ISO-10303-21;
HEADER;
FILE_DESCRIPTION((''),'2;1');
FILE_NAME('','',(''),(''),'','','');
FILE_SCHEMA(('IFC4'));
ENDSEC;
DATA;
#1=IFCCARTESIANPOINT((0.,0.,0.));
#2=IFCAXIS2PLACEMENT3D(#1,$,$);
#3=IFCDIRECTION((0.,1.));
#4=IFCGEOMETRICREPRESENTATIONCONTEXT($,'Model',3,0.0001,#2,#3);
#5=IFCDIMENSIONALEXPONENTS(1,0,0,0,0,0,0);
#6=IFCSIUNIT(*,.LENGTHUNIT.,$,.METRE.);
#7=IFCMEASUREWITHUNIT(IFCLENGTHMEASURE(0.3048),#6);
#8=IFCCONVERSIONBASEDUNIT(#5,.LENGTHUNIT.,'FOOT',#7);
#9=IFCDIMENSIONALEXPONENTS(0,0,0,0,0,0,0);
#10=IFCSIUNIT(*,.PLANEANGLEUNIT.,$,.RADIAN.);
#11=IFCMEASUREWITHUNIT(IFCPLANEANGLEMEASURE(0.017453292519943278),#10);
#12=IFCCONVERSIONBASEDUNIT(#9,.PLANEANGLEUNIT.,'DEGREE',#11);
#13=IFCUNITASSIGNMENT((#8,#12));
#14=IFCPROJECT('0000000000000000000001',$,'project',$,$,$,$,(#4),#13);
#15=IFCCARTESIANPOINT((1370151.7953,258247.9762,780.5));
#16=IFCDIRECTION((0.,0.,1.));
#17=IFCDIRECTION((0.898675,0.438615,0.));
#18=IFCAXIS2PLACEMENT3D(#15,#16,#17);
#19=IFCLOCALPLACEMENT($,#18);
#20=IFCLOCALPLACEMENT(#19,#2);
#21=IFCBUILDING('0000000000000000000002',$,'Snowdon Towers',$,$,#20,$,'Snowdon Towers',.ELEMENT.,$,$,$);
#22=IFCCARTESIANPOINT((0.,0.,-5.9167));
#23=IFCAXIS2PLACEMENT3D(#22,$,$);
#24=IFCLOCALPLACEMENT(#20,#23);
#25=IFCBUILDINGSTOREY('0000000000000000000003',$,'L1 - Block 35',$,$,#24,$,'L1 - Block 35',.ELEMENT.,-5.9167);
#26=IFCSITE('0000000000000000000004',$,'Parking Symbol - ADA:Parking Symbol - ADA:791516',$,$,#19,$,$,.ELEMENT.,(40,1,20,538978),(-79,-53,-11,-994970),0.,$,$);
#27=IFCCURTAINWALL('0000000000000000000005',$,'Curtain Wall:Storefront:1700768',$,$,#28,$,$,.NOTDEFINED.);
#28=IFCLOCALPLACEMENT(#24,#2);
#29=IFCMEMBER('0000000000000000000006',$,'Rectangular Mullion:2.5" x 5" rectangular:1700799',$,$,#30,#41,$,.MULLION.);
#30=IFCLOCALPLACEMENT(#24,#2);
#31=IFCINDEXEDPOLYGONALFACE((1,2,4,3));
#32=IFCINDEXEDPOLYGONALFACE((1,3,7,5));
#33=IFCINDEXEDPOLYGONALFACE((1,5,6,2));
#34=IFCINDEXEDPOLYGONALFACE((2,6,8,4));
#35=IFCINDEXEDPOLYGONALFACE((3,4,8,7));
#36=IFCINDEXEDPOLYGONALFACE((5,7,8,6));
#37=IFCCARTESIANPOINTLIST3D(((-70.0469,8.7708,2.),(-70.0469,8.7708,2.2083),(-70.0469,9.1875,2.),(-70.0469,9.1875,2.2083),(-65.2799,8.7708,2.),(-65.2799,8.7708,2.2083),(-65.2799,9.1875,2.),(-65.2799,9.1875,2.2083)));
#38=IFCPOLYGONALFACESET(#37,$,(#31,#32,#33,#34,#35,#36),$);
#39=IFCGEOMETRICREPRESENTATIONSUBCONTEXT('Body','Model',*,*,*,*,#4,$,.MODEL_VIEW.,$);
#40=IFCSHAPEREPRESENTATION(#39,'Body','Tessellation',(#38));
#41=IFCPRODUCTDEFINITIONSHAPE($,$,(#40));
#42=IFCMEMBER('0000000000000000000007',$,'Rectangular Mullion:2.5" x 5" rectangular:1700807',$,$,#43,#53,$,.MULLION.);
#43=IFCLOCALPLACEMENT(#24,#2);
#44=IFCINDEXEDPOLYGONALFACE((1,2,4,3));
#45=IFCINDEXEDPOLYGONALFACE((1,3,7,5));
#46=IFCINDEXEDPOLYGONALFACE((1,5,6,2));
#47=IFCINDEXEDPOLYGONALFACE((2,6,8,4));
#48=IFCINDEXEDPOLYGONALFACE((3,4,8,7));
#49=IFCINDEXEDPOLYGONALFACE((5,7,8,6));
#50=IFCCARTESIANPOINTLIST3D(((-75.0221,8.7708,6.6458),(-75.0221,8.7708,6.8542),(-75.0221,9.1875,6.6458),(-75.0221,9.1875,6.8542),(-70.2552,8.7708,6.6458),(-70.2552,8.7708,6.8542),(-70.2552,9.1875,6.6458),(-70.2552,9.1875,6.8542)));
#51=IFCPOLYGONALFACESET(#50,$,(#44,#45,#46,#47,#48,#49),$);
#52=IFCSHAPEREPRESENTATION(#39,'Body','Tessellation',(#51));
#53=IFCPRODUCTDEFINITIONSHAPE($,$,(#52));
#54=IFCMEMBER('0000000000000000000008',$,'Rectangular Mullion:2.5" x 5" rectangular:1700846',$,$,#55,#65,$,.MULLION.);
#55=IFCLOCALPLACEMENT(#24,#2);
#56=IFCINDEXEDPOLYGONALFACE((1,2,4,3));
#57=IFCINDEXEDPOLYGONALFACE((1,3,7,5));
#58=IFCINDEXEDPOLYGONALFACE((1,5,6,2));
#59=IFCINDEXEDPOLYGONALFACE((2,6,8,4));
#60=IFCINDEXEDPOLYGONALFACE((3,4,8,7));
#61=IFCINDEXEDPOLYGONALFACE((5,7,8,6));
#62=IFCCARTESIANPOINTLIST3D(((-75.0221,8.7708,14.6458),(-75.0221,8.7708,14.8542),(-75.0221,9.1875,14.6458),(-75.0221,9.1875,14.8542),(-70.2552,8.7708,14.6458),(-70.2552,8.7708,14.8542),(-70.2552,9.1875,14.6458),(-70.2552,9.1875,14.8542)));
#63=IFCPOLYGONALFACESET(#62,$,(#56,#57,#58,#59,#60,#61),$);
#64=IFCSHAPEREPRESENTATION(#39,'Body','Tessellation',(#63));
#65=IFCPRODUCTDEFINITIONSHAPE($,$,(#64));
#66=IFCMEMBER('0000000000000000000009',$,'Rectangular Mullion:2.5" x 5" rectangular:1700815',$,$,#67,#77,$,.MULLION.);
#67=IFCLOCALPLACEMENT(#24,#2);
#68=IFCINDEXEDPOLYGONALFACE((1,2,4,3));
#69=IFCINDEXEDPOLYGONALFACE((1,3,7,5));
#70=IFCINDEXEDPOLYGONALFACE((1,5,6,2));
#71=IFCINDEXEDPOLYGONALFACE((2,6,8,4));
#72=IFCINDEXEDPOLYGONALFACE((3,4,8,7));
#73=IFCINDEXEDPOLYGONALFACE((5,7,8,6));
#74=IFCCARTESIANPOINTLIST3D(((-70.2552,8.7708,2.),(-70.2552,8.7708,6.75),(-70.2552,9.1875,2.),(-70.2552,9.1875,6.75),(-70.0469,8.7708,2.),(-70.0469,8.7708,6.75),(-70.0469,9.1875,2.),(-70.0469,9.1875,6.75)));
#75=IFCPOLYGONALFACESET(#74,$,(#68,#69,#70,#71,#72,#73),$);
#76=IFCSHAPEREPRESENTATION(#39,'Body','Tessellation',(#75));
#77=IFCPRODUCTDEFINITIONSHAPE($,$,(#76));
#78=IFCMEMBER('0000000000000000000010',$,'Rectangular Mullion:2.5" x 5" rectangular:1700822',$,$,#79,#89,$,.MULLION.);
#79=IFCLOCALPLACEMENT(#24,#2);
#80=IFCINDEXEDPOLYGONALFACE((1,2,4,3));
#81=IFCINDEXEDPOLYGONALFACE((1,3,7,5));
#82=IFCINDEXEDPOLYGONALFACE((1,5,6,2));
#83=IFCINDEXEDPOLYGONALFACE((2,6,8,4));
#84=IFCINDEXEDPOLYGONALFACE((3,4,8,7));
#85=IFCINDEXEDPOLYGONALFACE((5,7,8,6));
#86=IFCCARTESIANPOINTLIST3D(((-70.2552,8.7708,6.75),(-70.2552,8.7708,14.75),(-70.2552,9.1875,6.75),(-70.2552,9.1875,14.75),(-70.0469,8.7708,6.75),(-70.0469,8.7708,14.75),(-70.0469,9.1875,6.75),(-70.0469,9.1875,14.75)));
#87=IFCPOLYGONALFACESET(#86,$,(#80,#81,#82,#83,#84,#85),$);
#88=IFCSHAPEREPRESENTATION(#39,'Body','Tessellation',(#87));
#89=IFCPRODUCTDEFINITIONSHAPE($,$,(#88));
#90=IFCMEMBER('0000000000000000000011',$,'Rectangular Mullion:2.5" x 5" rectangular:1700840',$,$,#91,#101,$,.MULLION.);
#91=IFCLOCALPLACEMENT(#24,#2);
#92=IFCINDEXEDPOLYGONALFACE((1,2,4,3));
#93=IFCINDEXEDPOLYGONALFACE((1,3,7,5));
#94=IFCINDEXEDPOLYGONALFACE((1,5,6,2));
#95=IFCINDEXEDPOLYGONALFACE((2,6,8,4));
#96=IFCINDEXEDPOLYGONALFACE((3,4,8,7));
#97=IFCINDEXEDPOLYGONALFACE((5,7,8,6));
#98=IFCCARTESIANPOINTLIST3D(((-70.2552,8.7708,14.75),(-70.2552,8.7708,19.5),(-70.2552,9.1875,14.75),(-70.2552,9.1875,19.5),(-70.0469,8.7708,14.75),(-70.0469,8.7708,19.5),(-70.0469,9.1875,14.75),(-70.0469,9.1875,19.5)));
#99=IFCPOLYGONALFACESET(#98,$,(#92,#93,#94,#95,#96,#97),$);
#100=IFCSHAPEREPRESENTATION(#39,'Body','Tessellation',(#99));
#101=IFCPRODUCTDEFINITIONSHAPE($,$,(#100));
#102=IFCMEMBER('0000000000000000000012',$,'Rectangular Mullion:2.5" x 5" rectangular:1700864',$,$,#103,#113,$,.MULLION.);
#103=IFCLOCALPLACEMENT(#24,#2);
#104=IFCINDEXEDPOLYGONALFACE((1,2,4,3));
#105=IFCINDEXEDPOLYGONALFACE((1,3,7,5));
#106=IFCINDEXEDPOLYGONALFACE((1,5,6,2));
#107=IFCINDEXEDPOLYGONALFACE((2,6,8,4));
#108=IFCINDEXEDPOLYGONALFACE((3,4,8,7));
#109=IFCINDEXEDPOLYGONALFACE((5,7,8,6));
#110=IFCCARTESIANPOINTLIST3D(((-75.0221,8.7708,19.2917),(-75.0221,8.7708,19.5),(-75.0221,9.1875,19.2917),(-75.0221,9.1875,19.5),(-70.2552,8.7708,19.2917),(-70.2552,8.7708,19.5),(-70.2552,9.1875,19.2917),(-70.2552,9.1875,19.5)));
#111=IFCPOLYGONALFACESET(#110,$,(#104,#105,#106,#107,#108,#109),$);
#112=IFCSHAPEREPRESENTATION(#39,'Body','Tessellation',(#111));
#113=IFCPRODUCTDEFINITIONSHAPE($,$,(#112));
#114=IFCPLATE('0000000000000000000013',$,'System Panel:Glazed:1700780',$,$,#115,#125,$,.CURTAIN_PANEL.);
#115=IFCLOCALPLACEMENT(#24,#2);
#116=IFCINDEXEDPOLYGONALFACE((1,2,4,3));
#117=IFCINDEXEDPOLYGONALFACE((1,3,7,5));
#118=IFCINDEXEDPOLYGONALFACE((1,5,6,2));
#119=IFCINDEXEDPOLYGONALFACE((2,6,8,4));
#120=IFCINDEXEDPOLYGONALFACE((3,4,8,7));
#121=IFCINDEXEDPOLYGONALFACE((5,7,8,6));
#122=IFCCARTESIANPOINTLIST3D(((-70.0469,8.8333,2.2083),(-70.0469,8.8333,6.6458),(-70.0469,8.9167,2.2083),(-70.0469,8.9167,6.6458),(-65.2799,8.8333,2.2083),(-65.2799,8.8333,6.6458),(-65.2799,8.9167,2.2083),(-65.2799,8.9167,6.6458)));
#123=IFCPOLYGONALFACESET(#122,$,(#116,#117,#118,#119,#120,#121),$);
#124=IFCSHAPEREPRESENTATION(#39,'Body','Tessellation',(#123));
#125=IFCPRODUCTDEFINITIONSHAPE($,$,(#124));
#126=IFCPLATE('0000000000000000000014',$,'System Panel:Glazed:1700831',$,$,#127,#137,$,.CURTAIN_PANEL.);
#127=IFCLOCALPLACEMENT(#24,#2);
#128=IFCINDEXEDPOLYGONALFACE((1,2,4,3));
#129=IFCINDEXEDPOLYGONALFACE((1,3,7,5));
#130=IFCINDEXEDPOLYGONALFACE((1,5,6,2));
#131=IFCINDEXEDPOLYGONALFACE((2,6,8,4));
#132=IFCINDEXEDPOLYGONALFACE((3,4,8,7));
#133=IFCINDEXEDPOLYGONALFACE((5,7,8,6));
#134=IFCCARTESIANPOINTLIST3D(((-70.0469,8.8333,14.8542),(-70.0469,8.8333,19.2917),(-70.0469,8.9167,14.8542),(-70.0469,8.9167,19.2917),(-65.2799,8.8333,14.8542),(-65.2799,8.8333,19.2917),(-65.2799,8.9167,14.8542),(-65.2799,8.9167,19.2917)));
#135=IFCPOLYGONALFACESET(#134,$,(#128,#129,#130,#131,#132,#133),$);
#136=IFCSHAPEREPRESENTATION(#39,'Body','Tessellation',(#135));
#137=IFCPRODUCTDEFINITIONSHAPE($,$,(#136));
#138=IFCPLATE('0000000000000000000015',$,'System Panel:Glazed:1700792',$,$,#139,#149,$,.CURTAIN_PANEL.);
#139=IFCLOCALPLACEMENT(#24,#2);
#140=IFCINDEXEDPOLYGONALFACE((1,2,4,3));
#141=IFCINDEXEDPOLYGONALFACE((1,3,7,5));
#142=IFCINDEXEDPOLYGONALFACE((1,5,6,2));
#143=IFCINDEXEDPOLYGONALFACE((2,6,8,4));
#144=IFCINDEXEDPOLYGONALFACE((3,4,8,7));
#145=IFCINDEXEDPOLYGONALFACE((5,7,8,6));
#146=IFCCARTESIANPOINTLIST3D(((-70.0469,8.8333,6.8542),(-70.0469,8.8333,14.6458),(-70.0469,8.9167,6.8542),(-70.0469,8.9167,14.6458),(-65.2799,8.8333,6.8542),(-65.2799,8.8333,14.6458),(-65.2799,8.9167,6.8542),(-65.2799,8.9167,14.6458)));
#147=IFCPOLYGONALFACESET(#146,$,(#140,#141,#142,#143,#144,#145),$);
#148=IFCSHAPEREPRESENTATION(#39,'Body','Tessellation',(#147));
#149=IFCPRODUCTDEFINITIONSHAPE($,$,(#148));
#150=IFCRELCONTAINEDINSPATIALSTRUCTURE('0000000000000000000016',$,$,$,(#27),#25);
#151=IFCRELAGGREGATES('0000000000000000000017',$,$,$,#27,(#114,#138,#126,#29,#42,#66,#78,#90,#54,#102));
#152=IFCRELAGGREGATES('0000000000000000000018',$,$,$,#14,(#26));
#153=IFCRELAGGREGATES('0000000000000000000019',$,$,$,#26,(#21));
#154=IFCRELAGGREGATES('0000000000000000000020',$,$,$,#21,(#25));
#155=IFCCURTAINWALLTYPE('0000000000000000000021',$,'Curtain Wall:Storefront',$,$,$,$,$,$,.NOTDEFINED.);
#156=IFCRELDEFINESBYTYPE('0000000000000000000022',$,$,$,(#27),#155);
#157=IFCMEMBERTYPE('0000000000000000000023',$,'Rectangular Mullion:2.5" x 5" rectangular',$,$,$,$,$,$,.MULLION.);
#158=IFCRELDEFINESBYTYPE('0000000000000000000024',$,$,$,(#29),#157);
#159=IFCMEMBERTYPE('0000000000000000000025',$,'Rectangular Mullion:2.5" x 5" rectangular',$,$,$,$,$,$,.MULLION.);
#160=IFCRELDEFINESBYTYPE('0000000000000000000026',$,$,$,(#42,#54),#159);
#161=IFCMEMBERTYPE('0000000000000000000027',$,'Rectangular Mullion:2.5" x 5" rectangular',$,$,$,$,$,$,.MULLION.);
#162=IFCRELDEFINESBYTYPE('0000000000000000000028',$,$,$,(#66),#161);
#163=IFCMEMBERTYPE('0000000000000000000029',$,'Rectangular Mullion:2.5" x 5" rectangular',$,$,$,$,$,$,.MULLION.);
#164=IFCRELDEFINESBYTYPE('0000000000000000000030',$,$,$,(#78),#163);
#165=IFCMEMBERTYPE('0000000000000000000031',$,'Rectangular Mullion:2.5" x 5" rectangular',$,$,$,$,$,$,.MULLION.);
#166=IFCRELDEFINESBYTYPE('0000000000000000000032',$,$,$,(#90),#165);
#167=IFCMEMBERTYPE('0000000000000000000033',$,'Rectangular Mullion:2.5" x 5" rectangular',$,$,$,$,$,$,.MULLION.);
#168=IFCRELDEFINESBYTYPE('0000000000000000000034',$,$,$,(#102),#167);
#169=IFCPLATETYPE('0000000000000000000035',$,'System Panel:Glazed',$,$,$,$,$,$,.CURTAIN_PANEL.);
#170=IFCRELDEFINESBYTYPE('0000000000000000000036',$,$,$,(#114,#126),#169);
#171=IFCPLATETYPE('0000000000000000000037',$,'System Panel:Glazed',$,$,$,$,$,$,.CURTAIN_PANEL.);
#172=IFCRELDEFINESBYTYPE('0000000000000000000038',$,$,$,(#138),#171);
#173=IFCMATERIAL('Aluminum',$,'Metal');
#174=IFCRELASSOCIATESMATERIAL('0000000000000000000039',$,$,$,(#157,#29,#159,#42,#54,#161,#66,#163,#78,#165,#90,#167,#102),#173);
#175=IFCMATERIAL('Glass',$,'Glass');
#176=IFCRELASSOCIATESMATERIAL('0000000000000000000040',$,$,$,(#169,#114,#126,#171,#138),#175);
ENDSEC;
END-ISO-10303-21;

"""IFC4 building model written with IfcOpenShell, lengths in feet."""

from ifc_helpers import new_model, entity, si_unit, converted_unit, direction, frame, origin, place, context, subcontext, project, spatial, indexed_curve, outline, extrude, source, transform, mapped, material, type_object, type_shapes, element, aggregate, save


model = new_model("IFC4")

# Units and contexts
model_context = context("Model", 3, precision=0.0001, world=origin(), true_north=direction((0.0, 1.0)))
body_context = subcontext(model_context, "Body", "Model", "MODEL_VIEW")
ifc_project = project(units=[converted_unit("LENGTHUNIT", "FOOT", entity("IfcLengthMeasure", 0.3048), si_unit("LENGTHUNIT", "METRE"), dimensions=[1, 0, 0, 0, 0, 0, 0]), converted_unit("PLANEANGLEUNIT", "DEGREE", entity("IfcPlaneAngleMeasure", 0.017453292519943278), si_unit("PLANEANGLEUNIT", "RADIAN"), dimensions=[0, 0, 0, 0, 0, 0, 0])], contexts=[model_context])

# Site, building, storey
site_placement = place(None, frame((1370151.7953, 258247.9762, 780.5), z_axis=(0.0, 0.0, 1.0), x_axis=(0.898675, 0.438615, 0.0)))
site = spatial("IfcSite", under=ifc_project, at=site_placement, Name="Parking Symbol - ADA:Parking Symbol - ADA:791516", CompositionType="ELEMENT", RefLatitude=(40, 1, 20, 538978), RefLongitude=(-79, -53, -11, -994970), RefElevation=0.0)
building_placement = place(site_placement, origin())
building = spatial("IfcBuilding", under=site, at=building_placement, Name="Snowdon Towers", LongName="Snowdon Towers", CompositionType="ELEMENT")
storey_placement = place(building_placement, frame((0.0, 0.0, -5.9167)))
storey = spatial("IfcBuildingStorey", under=building, at=storey_placement, Name="L1 - Block 35", LongName="L1 - Block 35", CompositionType="ELEMENT", Elevation=-5.9167)

# Curtain wall, members, plates
curtain_wall_type = type_object("IfcCurtainWallType", Name="Curtain Wall:Storefront", PredefinedType="NOTDEFINED")
curtain_wall_placement = place(storey_placement, frame((0.0, 0.0, 5.9167)))
curtain_wall = element("IfcCurtainWall", 1, at=curtain_wall_placement, inside=storey, type_object=curtain_wall_type, Name="Curtain Wall:Storefront:1700768", PredefinedType="NOTDEFINED")
ifc_material_1 = material(Name="Aluminum", Category="Metal")
member_type_1 = type_object("IfcMemberType", Name="Rectangular Mullion:2.5\" x 5\" rectangular", PredefinedType="MULLION", material=ifc_material_1)
shared_shape_1 = source(origin(), body_context, "Body", "SweptSolid", [
    extrude(outline(indexed_curve([(-0.1042, -0.2083), (0.1042, -0.2083), (0.1042, 0.2083), (-0.1042, 0.2083), (-0.1042, -0.2083)], self_intersect=False)), frame((-0.1042, 0.0, -4.7669), z_axis=(0.0, 0.0, 1.0), x_axis=(-1.0, 0.0, 0.0)), (0.0, 0.0, 1.0), 4.7669),
])
type_shapes(member_type_1, [shared_shape_1])
member_1_placement = place(curtain_wall_placement, frame((-70.0469, 8.9792, -3.9167), z_axis=(-1.0, 0.0, 0.0), x_axis=(0.0, 0.0, -1.0)))
member_1 = element("IfcMember", 2, at=member_1_placement, type_object=member_type_1, material=ifc_material_1, Name="Rectangular Mullion:2.5\" x 5\" rectangular:1700799", PredefinedType="MULLION", context=body_context, shape_type="MappedRepresentation", body=[
    mapped(shared_shape_1, transform((0.0, 0.0, 0.0), scale=1.0)),
])
member_type_2 = type_object("IfcMemberType", Name="Rectangular Mullion:2.5\" x 5\" rectangular", PredefinedType="MULLION", material=ifc_material_1)
shared_shape_2 = source(origin(), body_context, "Body", "SweptSolid", [
    extrude(outline(indexed_curve([(-0.1042, -0.2083), (0.1042, -0.2083), (0.1042, 0.2083), (-0.1042, 0.2083), (-0.1042, -0.2083)], self_intersect=False)), frame((0.0, 0.0, -4.7669), z_axis=(0.0, 0.0, 1.0), x_axis=(-1.0, 0.0, 0.0)), (0.0, 0.0, 1.0), 4.7669),
])
type_shapes(member_type_2, [shared_shape_2])
member_2_placement = place(curtain_wall_placement, frame((-70.2552, 8.9792, 0.8333), z_axis=(1.0, 0.0, 0.0), x_axis=(0.0, 0.0, 1.0)))
member_2 = element("IfcMember", 3, at=member_2_placement, type_object=member_type_2, material=ifc_material_1, Name="Rectangular Mullion:2.5\" x 5\" rectangular:1700807", PredefinedType="MULLION", context=body_context, shape_type="MappedRepresentation", body=[
    mapped(shared_shape_2, transform((0.0, 0.0, 0.0), scale=1.0)),
])
member_3_placement = place(curtain_wall_placement, frame((-70.2552, 8.9792, 8.8333), z_axis=(1.0, 0.0, 0.0), x_axis=(0.0, 0.0, 1.0)))
member_3 = element("IfcMember", 4, at=member_3_placement, type_object=member_type_2, material=ifc_material_1, Name="Rectangular Mullion:2.5\" x 5\" rectangular:1700846", PredefinedType="MULLION", context=body_context, shape_type="MappedRepresentation", body=[
    mapped(shared_shape_2, transform((0.0, 0.0, 0.0), scale=1.0)),
])
member_type_3 = type_object("IfcMemberType", Name="Rectangular Mullion:2.5\" x 5\" rectangular", PredefinedType="MULLION", material=ifc_material_1)
shared_shape_3 = source(origin(), body_context, "Body", "SweptSolid", [
    extrude(outline(indexed_curve([(-0.1042, -0.2083), (0.1042, -0.2083), (0.1042, 0.2083), (-0.1042, 0.2083), (-0.1042, -0.2083)], self_intersect=False)), frame((0.0, 0.0, -4.75), z_axis=(0.0, 0.0, 1.0), x_axis=(-1.0, 0.0, 0.0)), (0.0, 0.0, 1.0), 4.75),
])
type_shapes(member_type_3, [shared_shape_3])
member_4_placement = place(curtain_wall_placement, frame((-70.151, 8.9792, -3.9167), z_axis=(0.0, 0.0, -1.0), x_axis=(1.0, 0.0, 0.0)))
member_4 = element("IfcMember", 5, at=member_4_placement, type_object=member_type_3, material=ifc_material_1, Name="Rectangular Mullion:2.5\" x 5\" rectangular:1700815", PredefinedType="MULLION", context=body_context, shape_type="MappedRepresentation", body=[
    mapped(shared_shape_3, transform((0.0, 0.0, 0.0), scale=1.0)),
])
member_type_4 = type_object("IfcMemberType", Name="Rectangular Mullion:2.5\" x 5\" rectangular", PredefinedType="MULLION", material=ifc_material_1)
shared_shape_4 = source(origin(), body_context, "Body", "SweptSolid", [
    extrude(outline(indexed_curve([(-0.1042, -0.2083), (0.1042, -0.2083), (0.1042, 0.2083), (-0.1042, 0.2083), (-0.1042, -0.2083)], self_intersect=False)), frame((0.0, 0.0, -8.0), z_axis=(0.0, 0.0, 1.0), x_axis=(-1.0, 0.0, 0.0)), (0.0, 0.0, 1.0), 8.0),
])
type_shapes(member_type_4, [shared_shape_4])
member_5_placement = place(curtain_wall_placement, frame((-70.151, 8.9792, 0.8333), z_axis=(0.0, 0.0, -1.0), x_axis=(1.0, 0.0, 0.0)))
member_5 = element("IfcMember", 6, at=member_5_placement, type_object=member_type_4, material=ifc_material_1, Name="Rectangular Mullion:2.5\" x 5\" rectangular:1700822", PredefinedType="MULLION", context=body_context, shape_type="MappedRepresentation", body=[
    mapped(shared_shape_4, transform((0.0, 0.0, 0.0), scale=1.0)),
])
member_type_5 = type_object("IfcMemberType", Name="Rectangular Mullion:2.5\" x 5\" rectangular", PredefinedType="MULLION", material=ifc_material_1)
shared_shape_5 = source(origin(), body_context, "Body", "SweptSolid", [
    extrude(outline(indexed_curve([(-0.1042, -0.2083), (0.1042, -0.2083), (0.1042, 0.2083), (-0.1042, 0.2083), (-0.1042, -0.2083)], self_intersect=False)), frame((0.0, 0.0, -4.75), z_axis=(0.0, 0.0, 1.0), x_axis=(-1.0, 0.0, 0.0)), (0.0, 0.0, 1.0), 4.75),
])
type_shapes(member_type_5, [shared_shape_5])
member_6_placement = place(curtain_wall_placement, frame((-70.151, 8.9792, 8.8333), z_axis=(0.0, 0.0, -1.0), x_axis=(1.0, 0.0, 0.0)))
member_6 = element("IfcMember", 7, at=member_6_placement, type_object=member_type_5, material=ifc_material_1, Name="Rectangular Mullion:2.5\" x 5\" rectangular:1700840", PredefinedType="MULLION", context=body_context, shape_type="MappedRepresentation", body=[
    mapped(shared_shape_5, transform((0.0, 0.0, 0.0), scale=1.0)),
])
member_type_6 = type_object("IfcMemberType", Name="Rectangular Mullion:2.5\" x 5\" rectangular", PredefinedType="MULLION", material=ifc_material_1)
shared_shape_6 = source(origin(), body_context, "Body", "SweptSolid", [
    extrude(outline(indexed_curve([(-0.1042, -0.2083), (0.1042, -0.2083), (0.1042, 0.2083), (-0.1042, 0.2083), (-0.1042, -0.2083)], self_intersect=False)), frame((-0.1042, 0.0, -4.7669), z_axis=(0.0, 0.0, 1.0), x_axis=(-1.0, 0.0, 0.0)), (0.0, 0.0, 1.0), 4.7669),
])
type_shapes(member_type_6, [shared_shape_6])
member_7_placement = place(curtain_wall_placement, frame((-70.2552, 8.9792, 13.5833), z_axis=(1.0, 0.0, 0.0), x_axis=(0.0, 0.0, 1.0)))
member_7 = element("IfcMember", 8, at=member_7_placement, type_object=member_type_6, material=ifc_material_1, Name="Rectangular Mullion:2.5\" x 5\" rectangular:1700864", PredefinedType="MULLION", context=body_context, shape_type="MappedRepresentation", body=[
    mapped(shared_shape_6, transform((0.0, 0.0, 0.0), scale=1.0)),
])
ifc_material_2 = material(Name="Glass", Category="Glass")
plate_type_1 = type_object("IfcPlateType", Name="System Panel:Glazed", PredefinedType="CURTAIN_PANEL", material=ifc_material_2)
shared_shape_7 = source(origin(), body_context, "Body", "SweptSolid", [
    extrude(outline(indexed_curve([(-0.0417, -2.3835), (0.0417, -2.3835), (0.0417, 2.3835), (-0.0417, 2.3835), (-0.0417, -2.3835)], self_intersect=False)), frame((0.0, -0.1042, 0.0), z_axis=(0.0, 0.0, 1.0), x_axis=(0.0, 1.0, 0.0)), (0.0, 0.0, 1.0), 4.4375),
])
type_shapes(plate_type_1, [shared_shape_7])
plate_1_placement = place(curtain_wall_placement, frame((-67.6634, 8.9792, -3.7083)))
plate_1 = element("IfcPlate", 9, at=plate_1_placement, type_object=plate_type_1, material=ifc_material_2, Name="System Panel:Glazed:1700780", PredefinedType="CURTAIN_PANEL", context=body_context, shape_type="MappedRepresentation", body=[
    mapped(shared_shape_7, transform((0.0, 0.0, 0.0), scale=1.0)),
])
plate_2_placement = place(curtain_wall_placement, frame((-67.6634, 8.9792, 8.9375)))
plate_2 = element("IfcPlate", 10, at=plate_2_placement, type_object=plate_type_1, material=ifc_material_2, Name="System Panel:Glazed:1700831", PredefinedType="CURTAIN_PANEL", context=body_context, shape_type="MappedRepresentation", body=[
    mapped(shared_shape_7, transform((0.0, 0.0, 0.0), scale=1.0)),
])
plate_type_2 = type_object("IfcPlateType", Name="System Panel:Glazed", PredefinedType="CURTAIN_PANEL", material=ifc_material_2)
shared_shape_8 = source(origin(), body_context, "Body", "SweptSolid", [
    extrude(outline(indexed_curve([(-0.0417, -2.3835), (0.0417, -2.3835), (0.0417, 2.3835), (-0.0417, 2.3835), (-0.0417, -2.3835)], self_intersect=False)), frame((0.0, -0.1042, 0.0), z_axis=(0.0, 0.0, 1.0), x_axis=(0.0, 1.0, 0.0)), (0.0, 0.0, 1.0), 7.7917),
])
type_shapes(plate_type_2, [shared_shape_8])
plate_3_placement = place(curtain_wall_placement, frame((-67.6634, 8.9792, 0.9375)))
plate_3 = element("IfcPlate", 11, at=plate_3_placement, type_object=plate_type_2, material=ifc_material_2, Name="System Panel:Glazed:1700792", PredefinedType="CURTAIN_PANEL", context=body_context, shape_type="MappedRepresentation", body=[
    mapped(shared_shape_8, transform((0.0, 0.0, 0.0), scale=1.0)),
])
aggregate(curtain_wall, [plate_1, plate_3, plate_2, member_1, member_2, member_4, member_5, member_6, member_3, member_7])

save(model, "model.ifc")
